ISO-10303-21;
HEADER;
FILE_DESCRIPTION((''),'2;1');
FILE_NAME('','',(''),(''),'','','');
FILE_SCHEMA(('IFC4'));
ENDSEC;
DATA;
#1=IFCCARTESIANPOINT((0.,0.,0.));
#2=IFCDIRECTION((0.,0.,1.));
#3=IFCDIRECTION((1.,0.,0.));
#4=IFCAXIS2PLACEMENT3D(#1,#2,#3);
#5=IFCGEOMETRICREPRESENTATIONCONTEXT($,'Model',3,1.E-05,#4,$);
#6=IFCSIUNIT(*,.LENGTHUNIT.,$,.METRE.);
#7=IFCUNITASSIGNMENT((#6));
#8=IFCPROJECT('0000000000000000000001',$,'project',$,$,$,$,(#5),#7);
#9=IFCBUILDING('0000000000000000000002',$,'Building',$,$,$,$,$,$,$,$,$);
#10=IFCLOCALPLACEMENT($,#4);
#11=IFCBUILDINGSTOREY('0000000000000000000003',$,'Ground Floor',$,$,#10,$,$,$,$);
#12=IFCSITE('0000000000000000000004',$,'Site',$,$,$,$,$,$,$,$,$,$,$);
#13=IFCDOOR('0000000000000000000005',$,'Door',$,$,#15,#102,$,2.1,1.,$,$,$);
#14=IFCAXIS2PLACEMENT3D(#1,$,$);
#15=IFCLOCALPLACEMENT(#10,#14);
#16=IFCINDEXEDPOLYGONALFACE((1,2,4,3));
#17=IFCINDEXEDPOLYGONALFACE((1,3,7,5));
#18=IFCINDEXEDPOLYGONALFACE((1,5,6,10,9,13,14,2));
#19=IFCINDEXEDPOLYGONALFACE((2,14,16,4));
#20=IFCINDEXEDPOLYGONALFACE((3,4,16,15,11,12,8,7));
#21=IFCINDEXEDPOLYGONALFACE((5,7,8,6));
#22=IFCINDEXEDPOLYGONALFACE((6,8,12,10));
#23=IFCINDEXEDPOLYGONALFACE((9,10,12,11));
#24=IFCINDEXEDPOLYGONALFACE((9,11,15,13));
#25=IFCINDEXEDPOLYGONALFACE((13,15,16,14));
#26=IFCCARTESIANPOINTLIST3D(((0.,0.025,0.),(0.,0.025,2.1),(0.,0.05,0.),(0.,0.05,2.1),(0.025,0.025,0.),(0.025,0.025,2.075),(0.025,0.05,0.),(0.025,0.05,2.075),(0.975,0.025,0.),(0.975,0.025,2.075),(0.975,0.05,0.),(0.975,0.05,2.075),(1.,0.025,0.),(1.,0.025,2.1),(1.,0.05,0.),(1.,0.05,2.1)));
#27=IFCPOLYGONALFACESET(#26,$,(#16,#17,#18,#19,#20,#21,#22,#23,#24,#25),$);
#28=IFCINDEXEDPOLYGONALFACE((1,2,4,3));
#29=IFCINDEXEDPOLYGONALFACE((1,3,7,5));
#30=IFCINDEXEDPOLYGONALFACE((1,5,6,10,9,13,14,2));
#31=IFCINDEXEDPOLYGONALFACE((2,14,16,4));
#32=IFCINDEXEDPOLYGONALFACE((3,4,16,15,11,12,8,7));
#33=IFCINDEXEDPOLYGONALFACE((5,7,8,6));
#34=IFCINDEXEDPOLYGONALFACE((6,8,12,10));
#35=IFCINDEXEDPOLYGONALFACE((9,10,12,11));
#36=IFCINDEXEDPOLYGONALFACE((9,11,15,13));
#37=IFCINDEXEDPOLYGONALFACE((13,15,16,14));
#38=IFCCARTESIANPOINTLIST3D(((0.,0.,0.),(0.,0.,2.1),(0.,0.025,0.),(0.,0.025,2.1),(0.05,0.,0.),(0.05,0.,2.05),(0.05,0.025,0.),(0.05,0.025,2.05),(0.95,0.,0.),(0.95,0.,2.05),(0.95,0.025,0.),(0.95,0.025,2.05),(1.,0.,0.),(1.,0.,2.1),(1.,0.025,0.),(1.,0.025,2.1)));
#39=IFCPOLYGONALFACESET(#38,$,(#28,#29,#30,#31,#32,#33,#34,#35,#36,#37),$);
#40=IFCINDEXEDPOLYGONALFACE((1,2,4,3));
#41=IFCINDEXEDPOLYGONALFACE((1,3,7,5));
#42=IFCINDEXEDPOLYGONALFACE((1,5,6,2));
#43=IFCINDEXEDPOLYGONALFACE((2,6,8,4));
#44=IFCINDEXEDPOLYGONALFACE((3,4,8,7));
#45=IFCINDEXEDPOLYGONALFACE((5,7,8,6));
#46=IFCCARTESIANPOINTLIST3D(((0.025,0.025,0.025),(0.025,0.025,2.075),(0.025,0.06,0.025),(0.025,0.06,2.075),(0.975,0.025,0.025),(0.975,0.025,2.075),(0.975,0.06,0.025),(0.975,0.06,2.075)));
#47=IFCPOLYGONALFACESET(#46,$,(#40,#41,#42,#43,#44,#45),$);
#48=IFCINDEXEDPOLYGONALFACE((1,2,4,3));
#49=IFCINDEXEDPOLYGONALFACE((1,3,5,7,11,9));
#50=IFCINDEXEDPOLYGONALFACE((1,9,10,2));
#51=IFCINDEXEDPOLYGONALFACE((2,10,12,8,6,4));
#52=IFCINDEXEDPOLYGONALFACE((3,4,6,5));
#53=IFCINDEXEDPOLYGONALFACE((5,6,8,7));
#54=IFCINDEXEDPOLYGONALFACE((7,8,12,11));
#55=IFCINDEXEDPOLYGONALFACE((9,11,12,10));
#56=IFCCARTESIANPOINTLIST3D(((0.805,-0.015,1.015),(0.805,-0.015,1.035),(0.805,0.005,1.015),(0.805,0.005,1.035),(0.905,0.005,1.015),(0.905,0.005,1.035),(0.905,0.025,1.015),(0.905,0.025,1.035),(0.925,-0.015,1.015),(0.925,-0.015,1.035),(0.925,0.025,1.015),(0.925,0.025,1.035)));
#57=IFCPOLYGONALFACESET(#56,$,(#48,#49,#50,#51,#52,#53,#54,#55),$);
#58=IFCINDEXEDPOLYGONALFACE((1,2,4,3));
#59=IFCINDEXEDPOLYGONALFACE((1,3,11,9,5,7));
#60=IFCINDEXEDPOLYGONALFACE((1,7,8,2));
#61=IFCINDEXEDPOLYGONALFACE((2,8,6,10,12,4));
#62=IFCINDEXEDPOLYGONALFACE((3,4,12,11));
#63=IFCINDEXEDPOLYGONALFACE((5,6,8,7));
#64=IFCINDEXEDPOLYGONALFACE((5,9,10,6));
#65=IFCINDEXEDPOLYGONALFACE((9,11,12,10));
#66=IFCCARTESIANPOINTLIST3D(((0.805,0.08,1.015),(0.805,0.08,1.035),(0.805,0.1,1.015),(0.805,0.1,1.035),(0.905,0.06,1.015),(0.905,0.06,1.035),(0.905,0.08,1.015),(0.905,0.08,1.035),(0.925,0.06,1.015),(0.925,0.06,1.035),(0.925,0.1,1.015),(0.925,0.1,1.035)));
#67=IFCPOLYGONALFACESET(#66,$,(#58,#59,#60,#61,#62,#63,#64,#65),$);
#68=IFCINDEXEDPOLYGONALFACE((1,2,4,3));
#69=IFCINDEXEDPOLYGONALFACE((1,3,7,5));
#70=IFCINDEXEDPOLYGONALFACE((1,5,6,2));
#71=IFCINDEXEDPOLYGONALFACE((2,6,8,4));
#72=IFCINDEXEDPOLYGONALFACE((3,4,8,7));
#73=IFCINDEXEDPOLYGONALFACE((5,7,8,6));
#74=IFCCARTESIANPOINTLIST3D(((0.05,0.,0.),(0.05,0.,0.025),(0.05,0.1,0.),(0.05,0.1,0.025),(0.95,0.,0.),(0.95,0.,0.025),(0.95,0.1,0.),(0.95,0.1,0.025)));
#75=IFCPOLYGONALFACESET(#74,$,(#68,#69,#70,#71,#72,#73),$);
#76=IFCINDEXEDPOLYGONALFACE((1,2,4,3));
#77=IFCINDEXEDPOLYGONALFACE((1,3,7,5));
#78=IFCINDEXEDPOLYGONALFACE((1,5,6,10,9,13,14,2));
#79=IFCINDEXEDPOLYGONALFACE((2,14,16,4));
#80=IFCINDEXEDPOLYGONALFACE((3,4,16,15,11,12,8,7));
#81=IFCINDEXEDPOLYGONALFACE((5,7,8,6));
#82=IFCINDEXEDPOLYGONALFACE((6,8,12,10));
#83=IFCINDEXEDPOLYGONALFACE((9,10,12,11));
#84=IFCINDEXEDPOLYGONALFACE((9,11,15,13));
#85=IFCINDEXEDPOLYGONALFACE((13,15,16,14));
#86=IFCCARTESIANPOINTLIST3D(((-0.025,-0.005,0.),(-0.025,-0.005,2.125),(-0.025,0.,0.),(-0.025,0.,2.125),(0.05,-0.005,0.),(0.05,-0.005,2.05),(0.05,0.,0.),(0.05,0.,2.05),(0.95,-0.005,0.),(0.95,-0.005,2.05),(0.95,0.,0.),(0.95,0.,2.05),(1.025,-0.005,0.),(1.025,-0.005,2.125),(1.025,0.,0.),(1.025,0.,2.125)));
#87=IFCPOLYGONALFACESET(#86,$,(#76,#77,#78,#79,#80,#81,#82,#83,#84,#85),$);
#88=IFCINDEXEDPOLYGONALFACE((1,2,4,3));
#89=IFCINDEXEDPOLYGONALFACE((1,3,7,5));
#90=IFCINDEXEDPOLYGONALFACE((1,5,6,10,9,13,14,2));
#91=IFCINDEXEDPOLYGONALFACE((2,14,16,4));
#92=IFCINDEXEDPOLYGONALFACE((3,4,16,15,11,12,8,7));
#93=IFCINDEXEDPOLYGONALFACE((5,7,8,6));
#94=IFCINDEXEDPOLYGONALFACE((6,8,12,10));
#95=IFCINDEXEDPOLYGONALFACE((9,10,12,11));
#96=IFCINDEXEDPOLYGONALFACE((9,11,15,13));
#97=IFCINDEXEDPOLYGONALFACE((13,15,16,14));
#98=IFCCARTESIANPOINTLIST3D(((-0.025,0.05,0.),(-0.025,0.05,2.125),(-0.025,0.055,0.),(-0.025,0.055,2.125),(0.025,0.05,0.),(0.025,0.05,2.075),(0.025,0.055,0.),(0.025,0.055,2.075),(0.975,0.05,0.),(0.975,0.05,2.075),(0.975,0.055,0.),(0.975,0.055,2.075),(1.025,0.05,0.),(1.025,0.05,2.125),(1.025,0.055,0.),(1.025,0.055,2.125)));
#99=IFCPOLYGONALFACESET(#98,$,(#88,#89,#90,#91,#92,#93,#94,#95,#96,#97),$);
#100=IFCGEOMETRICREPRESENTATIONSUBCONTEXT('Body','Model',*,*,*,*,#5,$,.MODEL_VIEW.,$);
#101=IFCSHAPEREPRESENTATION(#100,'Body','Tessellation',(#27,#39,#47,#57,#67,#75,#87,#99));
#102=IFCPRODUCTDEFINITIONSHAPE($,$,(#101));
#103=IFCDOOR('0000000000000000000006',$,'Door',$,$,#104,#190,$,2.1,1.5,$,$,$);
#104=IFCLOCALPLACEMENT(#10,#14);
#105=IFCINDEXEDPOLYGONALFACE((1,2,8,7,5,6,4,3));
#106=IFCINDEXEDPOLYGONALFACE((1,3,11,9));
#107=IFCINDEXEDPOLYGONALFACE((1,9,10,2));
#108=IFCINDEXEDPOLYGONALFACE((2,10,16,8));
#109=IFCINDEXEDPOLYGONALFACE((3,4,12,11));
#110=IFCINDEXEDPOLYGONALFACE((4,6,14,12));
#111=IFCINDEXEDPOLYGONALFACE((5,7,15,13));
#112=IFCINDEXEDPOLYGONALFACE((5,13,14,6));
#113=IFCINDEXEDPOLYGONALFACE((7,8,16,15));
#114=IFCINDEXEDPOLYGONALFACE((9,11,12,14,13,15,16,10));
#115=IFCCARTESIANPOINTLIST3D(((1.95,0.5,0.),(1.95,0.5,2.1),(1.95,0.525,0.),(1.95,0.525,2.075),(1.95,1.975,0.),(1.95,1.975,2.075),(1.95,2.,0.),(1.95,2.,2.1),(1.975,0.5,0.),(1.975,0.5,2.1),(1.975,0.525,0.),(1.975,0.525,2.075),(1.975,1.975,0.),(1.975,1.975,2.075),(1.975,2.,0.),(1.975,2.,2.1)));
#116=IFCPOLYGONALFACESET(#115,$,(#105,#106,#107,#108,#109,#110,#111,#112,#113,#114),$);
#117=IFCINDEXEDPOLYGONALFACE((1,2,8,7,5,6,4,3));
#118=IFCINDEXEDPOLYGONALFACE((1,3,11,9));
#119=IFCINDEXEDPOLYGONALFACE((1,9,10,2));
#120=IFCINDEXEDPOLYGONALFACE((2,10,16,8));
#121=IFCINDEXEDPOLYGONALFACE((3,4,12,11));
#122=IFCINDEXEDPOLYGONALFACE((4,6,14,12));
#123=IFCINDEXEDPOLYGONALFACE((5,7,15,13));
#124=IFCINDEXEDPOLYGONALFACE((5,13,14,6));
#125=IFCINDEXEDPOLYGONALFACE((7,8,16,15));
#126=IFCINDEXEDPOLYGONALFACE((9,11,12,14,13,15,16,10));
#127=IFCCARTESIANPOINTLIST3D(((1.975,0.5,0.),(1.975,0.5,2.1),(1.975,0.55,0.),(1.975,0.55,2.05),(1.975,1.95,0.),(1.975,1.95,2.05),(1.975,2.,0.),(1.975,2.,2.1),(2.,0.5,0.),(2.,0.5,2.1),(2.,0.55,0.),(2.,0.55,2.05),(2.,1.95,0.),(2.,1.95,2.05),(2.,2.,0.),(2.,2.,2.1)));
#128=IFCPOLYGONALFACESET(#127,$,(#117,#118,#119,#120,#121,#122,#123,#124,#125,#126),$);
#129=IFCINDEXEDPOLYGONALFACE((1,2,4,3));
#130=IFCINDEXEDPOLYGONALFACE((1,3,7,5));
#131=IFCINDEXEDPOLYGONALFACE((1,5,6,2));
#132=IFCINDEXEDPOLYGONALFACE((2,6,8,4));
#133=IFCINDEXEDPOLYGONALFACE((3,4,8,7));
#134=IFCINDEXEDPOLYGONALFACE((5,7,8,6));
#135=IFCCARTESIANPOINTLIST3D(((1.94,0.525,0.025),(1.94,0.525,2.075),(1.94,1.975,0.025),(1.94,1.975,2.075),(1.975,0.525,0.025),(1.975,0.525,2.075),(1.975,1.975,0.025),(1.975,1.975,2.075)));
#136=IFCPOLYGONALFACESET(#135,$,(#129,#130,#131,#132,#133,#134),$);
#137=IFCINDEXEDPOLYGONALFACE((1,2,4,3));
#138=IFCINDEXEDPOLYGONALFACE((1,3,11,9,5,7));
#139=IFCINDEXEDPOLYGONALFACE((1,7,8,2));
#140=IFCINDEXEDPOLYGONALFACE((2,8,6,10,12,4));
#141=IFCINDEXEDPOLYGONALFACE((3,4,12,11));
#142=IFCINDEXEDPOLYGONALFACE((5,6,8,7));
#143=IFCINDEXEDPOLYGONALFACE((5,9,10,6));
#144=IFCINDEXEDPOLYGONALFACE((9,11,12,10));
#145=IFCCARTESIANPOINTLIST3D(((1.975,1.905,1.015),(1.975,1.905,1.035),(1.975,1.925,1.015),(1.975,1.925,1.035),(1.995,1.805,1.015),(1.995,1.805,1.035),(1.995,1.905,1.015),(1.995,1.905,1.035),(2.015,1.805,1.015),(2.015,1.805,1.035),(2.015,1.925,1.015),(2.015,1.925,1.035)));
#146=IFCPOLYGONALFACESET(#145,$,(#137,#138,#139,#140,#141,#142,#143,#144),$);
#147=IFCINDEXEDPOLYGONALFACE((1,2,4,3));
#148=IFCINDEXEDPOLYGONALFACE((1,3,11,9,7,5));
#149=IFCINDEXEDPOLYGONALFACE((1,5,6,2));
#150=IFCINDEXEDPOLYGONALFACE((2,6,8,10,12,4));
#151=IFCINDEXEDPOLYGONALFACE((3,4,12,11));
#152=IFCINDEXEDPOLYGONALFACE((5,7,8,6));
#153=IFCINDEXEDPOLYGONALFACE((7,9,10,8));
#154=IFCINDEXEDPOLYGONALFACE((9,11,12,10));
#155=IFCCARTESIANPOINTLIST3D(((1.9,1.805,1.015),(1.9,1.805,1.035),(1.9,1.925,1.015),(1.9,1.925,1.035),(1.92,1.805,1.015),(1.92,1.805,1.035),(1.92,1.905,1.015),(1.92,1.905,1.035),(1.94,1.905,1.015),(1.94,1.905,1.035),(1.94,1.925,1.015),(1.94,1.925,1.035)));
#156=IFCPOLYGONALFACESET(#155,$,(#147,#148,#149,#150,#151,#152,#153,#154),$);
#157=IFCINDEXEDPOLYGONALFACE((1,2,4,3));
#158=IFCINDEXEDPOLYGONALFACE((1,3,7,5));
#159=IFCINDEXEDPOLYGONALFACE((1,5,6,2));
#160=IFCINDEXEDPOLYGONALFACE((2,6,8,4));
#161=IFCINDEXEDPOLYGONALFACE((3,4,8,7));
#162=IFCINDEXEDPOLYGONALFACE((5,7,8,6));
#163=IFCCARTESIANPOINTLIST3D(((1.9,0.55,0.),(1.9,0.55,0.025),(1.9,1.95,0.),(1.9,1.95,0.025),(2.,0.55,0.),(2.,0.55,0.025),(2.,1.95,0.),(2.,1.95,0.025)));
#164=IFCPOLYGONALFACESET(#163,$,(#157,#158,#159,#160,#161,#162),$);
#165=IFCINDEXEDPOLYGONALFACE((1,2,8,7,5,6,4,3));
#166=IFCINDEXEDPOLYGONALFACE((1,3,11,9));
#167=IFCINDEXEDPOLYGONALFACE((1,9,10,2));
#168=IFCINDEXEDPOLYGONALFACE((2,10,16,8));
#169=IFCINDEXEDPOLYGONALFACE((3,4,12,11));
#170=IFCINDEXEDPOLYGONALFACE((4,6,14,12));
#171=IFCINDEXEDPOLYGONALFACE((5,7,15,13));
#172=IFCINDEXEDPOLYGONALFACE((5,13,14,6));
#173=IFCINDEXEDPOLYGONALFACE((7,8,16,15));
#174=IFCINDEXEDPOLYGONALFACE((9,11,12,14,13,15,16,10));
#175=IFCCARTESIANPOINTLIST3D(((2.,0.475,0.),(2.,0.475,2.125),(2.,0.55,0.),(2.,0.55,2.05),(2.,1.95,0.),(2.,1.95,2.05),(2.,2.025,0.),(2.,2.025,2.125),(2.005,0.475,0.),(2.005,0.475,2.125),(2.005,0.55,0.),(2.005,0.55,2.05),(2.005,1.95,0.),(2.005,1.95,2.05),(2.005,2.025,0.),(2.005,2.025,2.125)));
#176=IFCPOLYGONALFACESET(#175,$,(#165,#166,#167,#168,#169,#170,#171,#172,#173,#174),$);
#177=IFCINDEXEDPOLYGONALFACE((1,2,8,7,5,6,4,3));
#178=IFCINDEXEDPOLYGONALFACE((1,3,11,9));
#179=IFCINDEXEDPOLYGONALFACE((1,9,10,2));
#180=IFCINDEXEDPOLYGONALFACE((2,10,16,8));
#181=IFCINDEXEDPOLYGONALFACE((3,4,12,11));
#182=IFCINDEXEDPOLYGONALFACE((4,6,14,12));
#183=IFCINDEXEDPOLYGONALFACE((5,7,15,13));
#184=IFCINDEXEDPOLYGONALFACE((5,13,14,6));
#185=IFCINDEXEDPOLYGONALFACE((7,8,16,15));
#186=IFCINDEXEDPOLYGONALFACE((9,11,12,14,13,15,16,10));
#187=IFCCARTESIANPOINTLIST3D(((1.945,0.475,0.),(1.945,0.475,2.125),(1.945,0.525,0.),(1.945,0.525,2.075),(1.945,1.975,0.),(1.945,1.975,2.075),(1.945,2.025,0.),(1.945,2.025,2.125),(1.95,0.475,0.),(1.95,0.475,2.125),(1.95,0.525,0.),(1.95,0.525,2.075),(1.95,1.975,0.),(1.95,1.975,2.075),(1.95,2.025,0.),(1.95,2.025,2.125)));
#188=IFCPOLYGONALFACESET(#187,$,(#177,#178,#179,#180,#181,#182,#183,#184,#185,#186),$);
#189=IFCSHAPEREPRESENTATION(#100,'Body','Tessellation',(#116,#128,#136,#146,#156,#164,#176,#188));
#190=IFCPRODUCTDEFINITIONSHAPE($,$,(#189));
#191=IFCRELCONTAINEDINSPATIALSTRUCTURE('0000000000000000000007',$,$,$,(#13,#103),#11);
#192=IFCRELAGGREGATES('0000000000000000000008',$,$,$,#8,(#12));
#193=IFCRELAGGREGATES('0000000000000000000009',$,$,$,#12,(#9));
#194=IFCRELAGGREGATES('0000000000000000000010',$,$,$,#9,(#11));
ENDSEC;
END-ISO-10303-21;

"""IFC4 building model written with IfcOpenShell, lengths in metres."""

from ifc_helpers import new_model, si_unit, frame, origin_with_axes, place, context, subcontext, project, spatial, line, indexed_curve, outline, extrude, element, save


model = new_model("IFC4")

# Units and contexts
model_context = context("Model", 3, precision=1e-05, world=origin_with_axes())
body_context = subcontext(model_context, "Body", "Model", "MODEL_VIEW")
ifc_project = project(units=[si_unit("LENGTHUNIT", "METRE")], contexts=[model_context])

# Site, building, storey
site = spatial("IfcSite", under=ifc_project, Name="Site")
building = spatial("IfcBuilding", under=site, Name="Building")
storey_placement = place(None, origin_with_axes())
storey = spatial("IfcBuildingStorey", under=building, at=storey_placement, Name="Ground Floor")

# Doors
door_1_placement = place(storey_placement, origin_with_axes())
element("IfcDoor", 1, at=door_1_placement, inside=storey, Name="Door", OverallHeight=2.1, OverallWidth=1.0, context=body_context, shape_type="SweptSolid", body=[
    extrude(outline(indexed_curve([(0.0, 0.0), (0.0, 2.1), (1.0, 2.1), (1.0, 0.0), (0.975, 0.0), (0.975, 2.075), (0.025, 2.075), (0.025, 0.0)], segments=[line(1, 2, 3, 4, 5, 6, 7, 8, 1)])), frame((0.0, 0.025, 0.0), z_axis=(0.0, -1.0, 0.0), x_axis=(1.0, 0.0, 0.0)), (0.0, 0.0, -1.0), 0.025),
    extrude(outline(indexed_curve([(0.0, 0.0), (0.0, 2.1), (1.0, 2.1), (1.0, 0.0), (0.95, 0.0), (0.95, 2.05), (0.05, 2.05), (0.05, 0.0)], segments=[line(1, 2, 3, 4, 5, 6, 7, 8, 1)])), frame((0.0, 0.0, 0.0), z_axis=(0.0, -1.0, 0.0), x_axis=(1.0, 0.0, 0.0)), (0.0, 0.0, -1.0), 0.025),
    extrude(outline(indexed_curve([(0.0, 0.0), (0.95, 0.0), (0.95, 0.035), (0.0, 0.035)], segments=[line(1, 2, 3, 4, 1)])), frame((0.025, 0.025, 0.025), z_axis=(0.0, 0.0, 1.0), x_axis=(1.0, 0.0, 0.0)), (0.0, 0.0, 1.0), 2.05),
    extrude(outline(indexed_curve([(0.0, 0.0), (0.0, -0.04), (-0.12, -0.04), (-0.12, -0.02), (-0.02, -0.02), (-0.02, 0.0)], segments=[line(1, 2, 3, 4, 5, 6, 1)])), frame((0.925, 0.025, 1.015), z_axis=(0.0, 0.0, 1.0), x_axis=(1.0, 0.0, 0.0)), (0.0, 0.0, 1.0), 0.02),
    extrude(outline(indexed_curve([(0.0, 0.0), (0.0, 0.04), (-0.12, 0.04), (-0.12, 0.02), (-0.02, 0.02), (-0.02, 0.0)], segments=[line(1, 2, 3, 4, 5, 6, 1)])), frame((0.925, 0.06, 1.015), z_axis=(0.0, 0.0, 1.0), x_axis=(1.0, 0.0, 0.0)), (0.0, 0.0, 1.0), 0.02),
    extrude(outline(indexed_curve([(0.0, 0.0), (0.9, 0.0), (0.9, 0.1), (0.0, 0.1)], segments=[line(1, 2, 3, 4, 1)])), frame((0.05, 0.0, 0.0), z_axis=(0.0, 0.0, 1.0), x_axis=(1.0, 0.0, 0.0)), (0.0, 0.0, 1.0), 0.025),
    extrude(outline(indexed_curve([(0.0, 0.0), (0.0, 2.125), (1.05, 2.125), (1.05, 0.0), (0.975, 0.0), (0.975, 2.05), (0.075, 2.05), (0.075, 0.0)], segments=[line(1, 2, 3, 4, 5, 6, 7, 8, 1)])), frame((-0.025, -0.005, 0.0), z_axis=(0.0, -1.0, 0.0), x_axis=(1.0, 0.0, 0.0)), (0.0, 0.0, -1.0), 0.005),
    extrude(outline(indexed_curve([(0.0, 0.0), (0.0, 2.125), (1.05, 2.125), (1.05, 0.0), (1.0, 0.0), (1.0, 2.075), (0.05, 2.075), (0.05, 0.0)], segments=[line(1, 2, 3, 4, 5, 6, 7, 8, 1)])), frame((-0.025, 0.05, 0.0), z_axis=(0.0, -1.0, 0.0), x_axis=(1.0, 0.0, 0.0)), (0.0, 0.0, -1.0), 0.005),
])
door_2_placement = place(storey_placement, frame((2.0, 0.5, 0.0), z_axis=(0.0, 0.0, 1.0), x_axis=(0.0, 1.0, 0.0)))
element("IfcDoor", 2, at=door_2_placement, inside=storey, Name="Door", OverallHeight=2.1, OverallWidth=1.5, context=body_context, shape_type="SweptSolid", body=[
    extrude(outline(indexed_curve([(0.0, 0.0), (0.0, 2.1), (1.5, 2.1), (1.5, 0.0), (1.475, 0.0), (1.475, 2.075), (0.025, 2.075), (0.025, 0.0)], segments=[line(1, 2, 3, 4, 5, 6, 7, 8, 1)])), frame((0.0, 0.025, 0.0), z_axis=(0.0, -1.0, 0.0), x_axis=(1.0, 0.0, 0.0)), (0.0, 0.0, -1.0), 0.025),
    extrude(outline(indexed_curve([(0.0, 0.0), (0.0, 2.1), (1.5, 2.1), (1.5, 0.0), (1.45, 0.0), (1.45, 2.05), (0.05, 2.05), (0.05, 0.0)], segments=[line(1, 2, 3, 4, 5, 6, 7, 8, 1)])), frame((0.0, 0.0, 0.0), z_axis=(0.0, -1.0, 0.0), x_axis=(1.0, 0.0, 0.0)), (0.0, 0.0, -1.0), 0.025),
    extrude(outline(indexed_curve([(0.0, 0.0), (1.45, 0.0), (1.45, 0.035), (0.0, 0.035)], segments=[line(1, 2, 3, 4, 1)])), frame((0.025, 0.025, 0.025), z_axis=(0.0, 0.0, 1.0), x_axis=(1.0, 0.0, 0.0)), (0.0, 0.0, 1.0), 2.05),
    extrude(outline(indexed_curve([(0.0, 0.0), (0.0, -0.04), (-0.12, -0.04), (-0.12, -0.02), (-0.02, -0.02), (-0.02, 0.0)], segments=[line(1, 2, 3, 4, 5, 6, 1)])), frame((1.425, 0.025, 1.015), z_axis=(0.0, 0.0, 1.0), x_axis=(1.0, 0.0, 0.0)), (0.0, 0.0, 1.0), 0.02),
    extrude(outline(indexed_curve([(0.0, 0.0), (0.0, 0.04), (-0.12, 0.04), (-0.12, 0.02), (-0.02, 0.02), (-0.02, 0.0)], segments=[line(1, 2, 3, 4, 5, 6, 1)])), frame((1.425, 0.06, 1.015), z_axis=(0.0, 0.0, 1.0), x_axis=(1.0, 0.0, 0.0)), (0.0, 0.0, 1.0), 0.02),
    extrude(outline(indexed_curve([(0.0, 0.0), (1.4, 0.0), (1.4, 0.1), (0.0, 0.1)], segments=[line(1, 2, 3, 4, 1)])), frame((0.05, 0.0, 0.0), z_axis=(0.0, 0.0, 1.0), x_axis=(1.0, 0.0, 0.0)), (0.0, 0.0, 1.0), 0.025),
    extrude(outline(indexed_curve([(0.0, 0.0), (0.0, 2.125), (1.55, 2.125), (1.55, 0.0), (1.475, 0.0), (1.475, 2.05), (0.075, 2.05), (0.075, 0.0)], segments=[line(1, 2, 3, 4, 5, 6, 7, 8, 1)])), frame((-0.025, -0.005, 0.0), z_axis=(0.0, -1.0, 0.0), x_axis=(1.0, 0.0, 0.0)), (0.0, 0.0, -1.0), 0.005),
    extrude(outline(indexed_curve([(0.0, 0.0), (0.0, 2.125), (1.55, 2.125), (1.55, 0.0), (1.5, 0.0), (1.5, 2.075), (0.05, 2.075), (0.05, 0.0)], segments=[line(1, 2, 3, 4, 5, 6, 7, 8, 1)])), frame((-0.025, 0.05, 0.0), z_axis=(0.0, -1.0, 0.0), x_axis=(1.0, 0.0, 0.0)), (0.0, 0.0, -1.0), 0.005),
])

save(model, "model.ifc")
